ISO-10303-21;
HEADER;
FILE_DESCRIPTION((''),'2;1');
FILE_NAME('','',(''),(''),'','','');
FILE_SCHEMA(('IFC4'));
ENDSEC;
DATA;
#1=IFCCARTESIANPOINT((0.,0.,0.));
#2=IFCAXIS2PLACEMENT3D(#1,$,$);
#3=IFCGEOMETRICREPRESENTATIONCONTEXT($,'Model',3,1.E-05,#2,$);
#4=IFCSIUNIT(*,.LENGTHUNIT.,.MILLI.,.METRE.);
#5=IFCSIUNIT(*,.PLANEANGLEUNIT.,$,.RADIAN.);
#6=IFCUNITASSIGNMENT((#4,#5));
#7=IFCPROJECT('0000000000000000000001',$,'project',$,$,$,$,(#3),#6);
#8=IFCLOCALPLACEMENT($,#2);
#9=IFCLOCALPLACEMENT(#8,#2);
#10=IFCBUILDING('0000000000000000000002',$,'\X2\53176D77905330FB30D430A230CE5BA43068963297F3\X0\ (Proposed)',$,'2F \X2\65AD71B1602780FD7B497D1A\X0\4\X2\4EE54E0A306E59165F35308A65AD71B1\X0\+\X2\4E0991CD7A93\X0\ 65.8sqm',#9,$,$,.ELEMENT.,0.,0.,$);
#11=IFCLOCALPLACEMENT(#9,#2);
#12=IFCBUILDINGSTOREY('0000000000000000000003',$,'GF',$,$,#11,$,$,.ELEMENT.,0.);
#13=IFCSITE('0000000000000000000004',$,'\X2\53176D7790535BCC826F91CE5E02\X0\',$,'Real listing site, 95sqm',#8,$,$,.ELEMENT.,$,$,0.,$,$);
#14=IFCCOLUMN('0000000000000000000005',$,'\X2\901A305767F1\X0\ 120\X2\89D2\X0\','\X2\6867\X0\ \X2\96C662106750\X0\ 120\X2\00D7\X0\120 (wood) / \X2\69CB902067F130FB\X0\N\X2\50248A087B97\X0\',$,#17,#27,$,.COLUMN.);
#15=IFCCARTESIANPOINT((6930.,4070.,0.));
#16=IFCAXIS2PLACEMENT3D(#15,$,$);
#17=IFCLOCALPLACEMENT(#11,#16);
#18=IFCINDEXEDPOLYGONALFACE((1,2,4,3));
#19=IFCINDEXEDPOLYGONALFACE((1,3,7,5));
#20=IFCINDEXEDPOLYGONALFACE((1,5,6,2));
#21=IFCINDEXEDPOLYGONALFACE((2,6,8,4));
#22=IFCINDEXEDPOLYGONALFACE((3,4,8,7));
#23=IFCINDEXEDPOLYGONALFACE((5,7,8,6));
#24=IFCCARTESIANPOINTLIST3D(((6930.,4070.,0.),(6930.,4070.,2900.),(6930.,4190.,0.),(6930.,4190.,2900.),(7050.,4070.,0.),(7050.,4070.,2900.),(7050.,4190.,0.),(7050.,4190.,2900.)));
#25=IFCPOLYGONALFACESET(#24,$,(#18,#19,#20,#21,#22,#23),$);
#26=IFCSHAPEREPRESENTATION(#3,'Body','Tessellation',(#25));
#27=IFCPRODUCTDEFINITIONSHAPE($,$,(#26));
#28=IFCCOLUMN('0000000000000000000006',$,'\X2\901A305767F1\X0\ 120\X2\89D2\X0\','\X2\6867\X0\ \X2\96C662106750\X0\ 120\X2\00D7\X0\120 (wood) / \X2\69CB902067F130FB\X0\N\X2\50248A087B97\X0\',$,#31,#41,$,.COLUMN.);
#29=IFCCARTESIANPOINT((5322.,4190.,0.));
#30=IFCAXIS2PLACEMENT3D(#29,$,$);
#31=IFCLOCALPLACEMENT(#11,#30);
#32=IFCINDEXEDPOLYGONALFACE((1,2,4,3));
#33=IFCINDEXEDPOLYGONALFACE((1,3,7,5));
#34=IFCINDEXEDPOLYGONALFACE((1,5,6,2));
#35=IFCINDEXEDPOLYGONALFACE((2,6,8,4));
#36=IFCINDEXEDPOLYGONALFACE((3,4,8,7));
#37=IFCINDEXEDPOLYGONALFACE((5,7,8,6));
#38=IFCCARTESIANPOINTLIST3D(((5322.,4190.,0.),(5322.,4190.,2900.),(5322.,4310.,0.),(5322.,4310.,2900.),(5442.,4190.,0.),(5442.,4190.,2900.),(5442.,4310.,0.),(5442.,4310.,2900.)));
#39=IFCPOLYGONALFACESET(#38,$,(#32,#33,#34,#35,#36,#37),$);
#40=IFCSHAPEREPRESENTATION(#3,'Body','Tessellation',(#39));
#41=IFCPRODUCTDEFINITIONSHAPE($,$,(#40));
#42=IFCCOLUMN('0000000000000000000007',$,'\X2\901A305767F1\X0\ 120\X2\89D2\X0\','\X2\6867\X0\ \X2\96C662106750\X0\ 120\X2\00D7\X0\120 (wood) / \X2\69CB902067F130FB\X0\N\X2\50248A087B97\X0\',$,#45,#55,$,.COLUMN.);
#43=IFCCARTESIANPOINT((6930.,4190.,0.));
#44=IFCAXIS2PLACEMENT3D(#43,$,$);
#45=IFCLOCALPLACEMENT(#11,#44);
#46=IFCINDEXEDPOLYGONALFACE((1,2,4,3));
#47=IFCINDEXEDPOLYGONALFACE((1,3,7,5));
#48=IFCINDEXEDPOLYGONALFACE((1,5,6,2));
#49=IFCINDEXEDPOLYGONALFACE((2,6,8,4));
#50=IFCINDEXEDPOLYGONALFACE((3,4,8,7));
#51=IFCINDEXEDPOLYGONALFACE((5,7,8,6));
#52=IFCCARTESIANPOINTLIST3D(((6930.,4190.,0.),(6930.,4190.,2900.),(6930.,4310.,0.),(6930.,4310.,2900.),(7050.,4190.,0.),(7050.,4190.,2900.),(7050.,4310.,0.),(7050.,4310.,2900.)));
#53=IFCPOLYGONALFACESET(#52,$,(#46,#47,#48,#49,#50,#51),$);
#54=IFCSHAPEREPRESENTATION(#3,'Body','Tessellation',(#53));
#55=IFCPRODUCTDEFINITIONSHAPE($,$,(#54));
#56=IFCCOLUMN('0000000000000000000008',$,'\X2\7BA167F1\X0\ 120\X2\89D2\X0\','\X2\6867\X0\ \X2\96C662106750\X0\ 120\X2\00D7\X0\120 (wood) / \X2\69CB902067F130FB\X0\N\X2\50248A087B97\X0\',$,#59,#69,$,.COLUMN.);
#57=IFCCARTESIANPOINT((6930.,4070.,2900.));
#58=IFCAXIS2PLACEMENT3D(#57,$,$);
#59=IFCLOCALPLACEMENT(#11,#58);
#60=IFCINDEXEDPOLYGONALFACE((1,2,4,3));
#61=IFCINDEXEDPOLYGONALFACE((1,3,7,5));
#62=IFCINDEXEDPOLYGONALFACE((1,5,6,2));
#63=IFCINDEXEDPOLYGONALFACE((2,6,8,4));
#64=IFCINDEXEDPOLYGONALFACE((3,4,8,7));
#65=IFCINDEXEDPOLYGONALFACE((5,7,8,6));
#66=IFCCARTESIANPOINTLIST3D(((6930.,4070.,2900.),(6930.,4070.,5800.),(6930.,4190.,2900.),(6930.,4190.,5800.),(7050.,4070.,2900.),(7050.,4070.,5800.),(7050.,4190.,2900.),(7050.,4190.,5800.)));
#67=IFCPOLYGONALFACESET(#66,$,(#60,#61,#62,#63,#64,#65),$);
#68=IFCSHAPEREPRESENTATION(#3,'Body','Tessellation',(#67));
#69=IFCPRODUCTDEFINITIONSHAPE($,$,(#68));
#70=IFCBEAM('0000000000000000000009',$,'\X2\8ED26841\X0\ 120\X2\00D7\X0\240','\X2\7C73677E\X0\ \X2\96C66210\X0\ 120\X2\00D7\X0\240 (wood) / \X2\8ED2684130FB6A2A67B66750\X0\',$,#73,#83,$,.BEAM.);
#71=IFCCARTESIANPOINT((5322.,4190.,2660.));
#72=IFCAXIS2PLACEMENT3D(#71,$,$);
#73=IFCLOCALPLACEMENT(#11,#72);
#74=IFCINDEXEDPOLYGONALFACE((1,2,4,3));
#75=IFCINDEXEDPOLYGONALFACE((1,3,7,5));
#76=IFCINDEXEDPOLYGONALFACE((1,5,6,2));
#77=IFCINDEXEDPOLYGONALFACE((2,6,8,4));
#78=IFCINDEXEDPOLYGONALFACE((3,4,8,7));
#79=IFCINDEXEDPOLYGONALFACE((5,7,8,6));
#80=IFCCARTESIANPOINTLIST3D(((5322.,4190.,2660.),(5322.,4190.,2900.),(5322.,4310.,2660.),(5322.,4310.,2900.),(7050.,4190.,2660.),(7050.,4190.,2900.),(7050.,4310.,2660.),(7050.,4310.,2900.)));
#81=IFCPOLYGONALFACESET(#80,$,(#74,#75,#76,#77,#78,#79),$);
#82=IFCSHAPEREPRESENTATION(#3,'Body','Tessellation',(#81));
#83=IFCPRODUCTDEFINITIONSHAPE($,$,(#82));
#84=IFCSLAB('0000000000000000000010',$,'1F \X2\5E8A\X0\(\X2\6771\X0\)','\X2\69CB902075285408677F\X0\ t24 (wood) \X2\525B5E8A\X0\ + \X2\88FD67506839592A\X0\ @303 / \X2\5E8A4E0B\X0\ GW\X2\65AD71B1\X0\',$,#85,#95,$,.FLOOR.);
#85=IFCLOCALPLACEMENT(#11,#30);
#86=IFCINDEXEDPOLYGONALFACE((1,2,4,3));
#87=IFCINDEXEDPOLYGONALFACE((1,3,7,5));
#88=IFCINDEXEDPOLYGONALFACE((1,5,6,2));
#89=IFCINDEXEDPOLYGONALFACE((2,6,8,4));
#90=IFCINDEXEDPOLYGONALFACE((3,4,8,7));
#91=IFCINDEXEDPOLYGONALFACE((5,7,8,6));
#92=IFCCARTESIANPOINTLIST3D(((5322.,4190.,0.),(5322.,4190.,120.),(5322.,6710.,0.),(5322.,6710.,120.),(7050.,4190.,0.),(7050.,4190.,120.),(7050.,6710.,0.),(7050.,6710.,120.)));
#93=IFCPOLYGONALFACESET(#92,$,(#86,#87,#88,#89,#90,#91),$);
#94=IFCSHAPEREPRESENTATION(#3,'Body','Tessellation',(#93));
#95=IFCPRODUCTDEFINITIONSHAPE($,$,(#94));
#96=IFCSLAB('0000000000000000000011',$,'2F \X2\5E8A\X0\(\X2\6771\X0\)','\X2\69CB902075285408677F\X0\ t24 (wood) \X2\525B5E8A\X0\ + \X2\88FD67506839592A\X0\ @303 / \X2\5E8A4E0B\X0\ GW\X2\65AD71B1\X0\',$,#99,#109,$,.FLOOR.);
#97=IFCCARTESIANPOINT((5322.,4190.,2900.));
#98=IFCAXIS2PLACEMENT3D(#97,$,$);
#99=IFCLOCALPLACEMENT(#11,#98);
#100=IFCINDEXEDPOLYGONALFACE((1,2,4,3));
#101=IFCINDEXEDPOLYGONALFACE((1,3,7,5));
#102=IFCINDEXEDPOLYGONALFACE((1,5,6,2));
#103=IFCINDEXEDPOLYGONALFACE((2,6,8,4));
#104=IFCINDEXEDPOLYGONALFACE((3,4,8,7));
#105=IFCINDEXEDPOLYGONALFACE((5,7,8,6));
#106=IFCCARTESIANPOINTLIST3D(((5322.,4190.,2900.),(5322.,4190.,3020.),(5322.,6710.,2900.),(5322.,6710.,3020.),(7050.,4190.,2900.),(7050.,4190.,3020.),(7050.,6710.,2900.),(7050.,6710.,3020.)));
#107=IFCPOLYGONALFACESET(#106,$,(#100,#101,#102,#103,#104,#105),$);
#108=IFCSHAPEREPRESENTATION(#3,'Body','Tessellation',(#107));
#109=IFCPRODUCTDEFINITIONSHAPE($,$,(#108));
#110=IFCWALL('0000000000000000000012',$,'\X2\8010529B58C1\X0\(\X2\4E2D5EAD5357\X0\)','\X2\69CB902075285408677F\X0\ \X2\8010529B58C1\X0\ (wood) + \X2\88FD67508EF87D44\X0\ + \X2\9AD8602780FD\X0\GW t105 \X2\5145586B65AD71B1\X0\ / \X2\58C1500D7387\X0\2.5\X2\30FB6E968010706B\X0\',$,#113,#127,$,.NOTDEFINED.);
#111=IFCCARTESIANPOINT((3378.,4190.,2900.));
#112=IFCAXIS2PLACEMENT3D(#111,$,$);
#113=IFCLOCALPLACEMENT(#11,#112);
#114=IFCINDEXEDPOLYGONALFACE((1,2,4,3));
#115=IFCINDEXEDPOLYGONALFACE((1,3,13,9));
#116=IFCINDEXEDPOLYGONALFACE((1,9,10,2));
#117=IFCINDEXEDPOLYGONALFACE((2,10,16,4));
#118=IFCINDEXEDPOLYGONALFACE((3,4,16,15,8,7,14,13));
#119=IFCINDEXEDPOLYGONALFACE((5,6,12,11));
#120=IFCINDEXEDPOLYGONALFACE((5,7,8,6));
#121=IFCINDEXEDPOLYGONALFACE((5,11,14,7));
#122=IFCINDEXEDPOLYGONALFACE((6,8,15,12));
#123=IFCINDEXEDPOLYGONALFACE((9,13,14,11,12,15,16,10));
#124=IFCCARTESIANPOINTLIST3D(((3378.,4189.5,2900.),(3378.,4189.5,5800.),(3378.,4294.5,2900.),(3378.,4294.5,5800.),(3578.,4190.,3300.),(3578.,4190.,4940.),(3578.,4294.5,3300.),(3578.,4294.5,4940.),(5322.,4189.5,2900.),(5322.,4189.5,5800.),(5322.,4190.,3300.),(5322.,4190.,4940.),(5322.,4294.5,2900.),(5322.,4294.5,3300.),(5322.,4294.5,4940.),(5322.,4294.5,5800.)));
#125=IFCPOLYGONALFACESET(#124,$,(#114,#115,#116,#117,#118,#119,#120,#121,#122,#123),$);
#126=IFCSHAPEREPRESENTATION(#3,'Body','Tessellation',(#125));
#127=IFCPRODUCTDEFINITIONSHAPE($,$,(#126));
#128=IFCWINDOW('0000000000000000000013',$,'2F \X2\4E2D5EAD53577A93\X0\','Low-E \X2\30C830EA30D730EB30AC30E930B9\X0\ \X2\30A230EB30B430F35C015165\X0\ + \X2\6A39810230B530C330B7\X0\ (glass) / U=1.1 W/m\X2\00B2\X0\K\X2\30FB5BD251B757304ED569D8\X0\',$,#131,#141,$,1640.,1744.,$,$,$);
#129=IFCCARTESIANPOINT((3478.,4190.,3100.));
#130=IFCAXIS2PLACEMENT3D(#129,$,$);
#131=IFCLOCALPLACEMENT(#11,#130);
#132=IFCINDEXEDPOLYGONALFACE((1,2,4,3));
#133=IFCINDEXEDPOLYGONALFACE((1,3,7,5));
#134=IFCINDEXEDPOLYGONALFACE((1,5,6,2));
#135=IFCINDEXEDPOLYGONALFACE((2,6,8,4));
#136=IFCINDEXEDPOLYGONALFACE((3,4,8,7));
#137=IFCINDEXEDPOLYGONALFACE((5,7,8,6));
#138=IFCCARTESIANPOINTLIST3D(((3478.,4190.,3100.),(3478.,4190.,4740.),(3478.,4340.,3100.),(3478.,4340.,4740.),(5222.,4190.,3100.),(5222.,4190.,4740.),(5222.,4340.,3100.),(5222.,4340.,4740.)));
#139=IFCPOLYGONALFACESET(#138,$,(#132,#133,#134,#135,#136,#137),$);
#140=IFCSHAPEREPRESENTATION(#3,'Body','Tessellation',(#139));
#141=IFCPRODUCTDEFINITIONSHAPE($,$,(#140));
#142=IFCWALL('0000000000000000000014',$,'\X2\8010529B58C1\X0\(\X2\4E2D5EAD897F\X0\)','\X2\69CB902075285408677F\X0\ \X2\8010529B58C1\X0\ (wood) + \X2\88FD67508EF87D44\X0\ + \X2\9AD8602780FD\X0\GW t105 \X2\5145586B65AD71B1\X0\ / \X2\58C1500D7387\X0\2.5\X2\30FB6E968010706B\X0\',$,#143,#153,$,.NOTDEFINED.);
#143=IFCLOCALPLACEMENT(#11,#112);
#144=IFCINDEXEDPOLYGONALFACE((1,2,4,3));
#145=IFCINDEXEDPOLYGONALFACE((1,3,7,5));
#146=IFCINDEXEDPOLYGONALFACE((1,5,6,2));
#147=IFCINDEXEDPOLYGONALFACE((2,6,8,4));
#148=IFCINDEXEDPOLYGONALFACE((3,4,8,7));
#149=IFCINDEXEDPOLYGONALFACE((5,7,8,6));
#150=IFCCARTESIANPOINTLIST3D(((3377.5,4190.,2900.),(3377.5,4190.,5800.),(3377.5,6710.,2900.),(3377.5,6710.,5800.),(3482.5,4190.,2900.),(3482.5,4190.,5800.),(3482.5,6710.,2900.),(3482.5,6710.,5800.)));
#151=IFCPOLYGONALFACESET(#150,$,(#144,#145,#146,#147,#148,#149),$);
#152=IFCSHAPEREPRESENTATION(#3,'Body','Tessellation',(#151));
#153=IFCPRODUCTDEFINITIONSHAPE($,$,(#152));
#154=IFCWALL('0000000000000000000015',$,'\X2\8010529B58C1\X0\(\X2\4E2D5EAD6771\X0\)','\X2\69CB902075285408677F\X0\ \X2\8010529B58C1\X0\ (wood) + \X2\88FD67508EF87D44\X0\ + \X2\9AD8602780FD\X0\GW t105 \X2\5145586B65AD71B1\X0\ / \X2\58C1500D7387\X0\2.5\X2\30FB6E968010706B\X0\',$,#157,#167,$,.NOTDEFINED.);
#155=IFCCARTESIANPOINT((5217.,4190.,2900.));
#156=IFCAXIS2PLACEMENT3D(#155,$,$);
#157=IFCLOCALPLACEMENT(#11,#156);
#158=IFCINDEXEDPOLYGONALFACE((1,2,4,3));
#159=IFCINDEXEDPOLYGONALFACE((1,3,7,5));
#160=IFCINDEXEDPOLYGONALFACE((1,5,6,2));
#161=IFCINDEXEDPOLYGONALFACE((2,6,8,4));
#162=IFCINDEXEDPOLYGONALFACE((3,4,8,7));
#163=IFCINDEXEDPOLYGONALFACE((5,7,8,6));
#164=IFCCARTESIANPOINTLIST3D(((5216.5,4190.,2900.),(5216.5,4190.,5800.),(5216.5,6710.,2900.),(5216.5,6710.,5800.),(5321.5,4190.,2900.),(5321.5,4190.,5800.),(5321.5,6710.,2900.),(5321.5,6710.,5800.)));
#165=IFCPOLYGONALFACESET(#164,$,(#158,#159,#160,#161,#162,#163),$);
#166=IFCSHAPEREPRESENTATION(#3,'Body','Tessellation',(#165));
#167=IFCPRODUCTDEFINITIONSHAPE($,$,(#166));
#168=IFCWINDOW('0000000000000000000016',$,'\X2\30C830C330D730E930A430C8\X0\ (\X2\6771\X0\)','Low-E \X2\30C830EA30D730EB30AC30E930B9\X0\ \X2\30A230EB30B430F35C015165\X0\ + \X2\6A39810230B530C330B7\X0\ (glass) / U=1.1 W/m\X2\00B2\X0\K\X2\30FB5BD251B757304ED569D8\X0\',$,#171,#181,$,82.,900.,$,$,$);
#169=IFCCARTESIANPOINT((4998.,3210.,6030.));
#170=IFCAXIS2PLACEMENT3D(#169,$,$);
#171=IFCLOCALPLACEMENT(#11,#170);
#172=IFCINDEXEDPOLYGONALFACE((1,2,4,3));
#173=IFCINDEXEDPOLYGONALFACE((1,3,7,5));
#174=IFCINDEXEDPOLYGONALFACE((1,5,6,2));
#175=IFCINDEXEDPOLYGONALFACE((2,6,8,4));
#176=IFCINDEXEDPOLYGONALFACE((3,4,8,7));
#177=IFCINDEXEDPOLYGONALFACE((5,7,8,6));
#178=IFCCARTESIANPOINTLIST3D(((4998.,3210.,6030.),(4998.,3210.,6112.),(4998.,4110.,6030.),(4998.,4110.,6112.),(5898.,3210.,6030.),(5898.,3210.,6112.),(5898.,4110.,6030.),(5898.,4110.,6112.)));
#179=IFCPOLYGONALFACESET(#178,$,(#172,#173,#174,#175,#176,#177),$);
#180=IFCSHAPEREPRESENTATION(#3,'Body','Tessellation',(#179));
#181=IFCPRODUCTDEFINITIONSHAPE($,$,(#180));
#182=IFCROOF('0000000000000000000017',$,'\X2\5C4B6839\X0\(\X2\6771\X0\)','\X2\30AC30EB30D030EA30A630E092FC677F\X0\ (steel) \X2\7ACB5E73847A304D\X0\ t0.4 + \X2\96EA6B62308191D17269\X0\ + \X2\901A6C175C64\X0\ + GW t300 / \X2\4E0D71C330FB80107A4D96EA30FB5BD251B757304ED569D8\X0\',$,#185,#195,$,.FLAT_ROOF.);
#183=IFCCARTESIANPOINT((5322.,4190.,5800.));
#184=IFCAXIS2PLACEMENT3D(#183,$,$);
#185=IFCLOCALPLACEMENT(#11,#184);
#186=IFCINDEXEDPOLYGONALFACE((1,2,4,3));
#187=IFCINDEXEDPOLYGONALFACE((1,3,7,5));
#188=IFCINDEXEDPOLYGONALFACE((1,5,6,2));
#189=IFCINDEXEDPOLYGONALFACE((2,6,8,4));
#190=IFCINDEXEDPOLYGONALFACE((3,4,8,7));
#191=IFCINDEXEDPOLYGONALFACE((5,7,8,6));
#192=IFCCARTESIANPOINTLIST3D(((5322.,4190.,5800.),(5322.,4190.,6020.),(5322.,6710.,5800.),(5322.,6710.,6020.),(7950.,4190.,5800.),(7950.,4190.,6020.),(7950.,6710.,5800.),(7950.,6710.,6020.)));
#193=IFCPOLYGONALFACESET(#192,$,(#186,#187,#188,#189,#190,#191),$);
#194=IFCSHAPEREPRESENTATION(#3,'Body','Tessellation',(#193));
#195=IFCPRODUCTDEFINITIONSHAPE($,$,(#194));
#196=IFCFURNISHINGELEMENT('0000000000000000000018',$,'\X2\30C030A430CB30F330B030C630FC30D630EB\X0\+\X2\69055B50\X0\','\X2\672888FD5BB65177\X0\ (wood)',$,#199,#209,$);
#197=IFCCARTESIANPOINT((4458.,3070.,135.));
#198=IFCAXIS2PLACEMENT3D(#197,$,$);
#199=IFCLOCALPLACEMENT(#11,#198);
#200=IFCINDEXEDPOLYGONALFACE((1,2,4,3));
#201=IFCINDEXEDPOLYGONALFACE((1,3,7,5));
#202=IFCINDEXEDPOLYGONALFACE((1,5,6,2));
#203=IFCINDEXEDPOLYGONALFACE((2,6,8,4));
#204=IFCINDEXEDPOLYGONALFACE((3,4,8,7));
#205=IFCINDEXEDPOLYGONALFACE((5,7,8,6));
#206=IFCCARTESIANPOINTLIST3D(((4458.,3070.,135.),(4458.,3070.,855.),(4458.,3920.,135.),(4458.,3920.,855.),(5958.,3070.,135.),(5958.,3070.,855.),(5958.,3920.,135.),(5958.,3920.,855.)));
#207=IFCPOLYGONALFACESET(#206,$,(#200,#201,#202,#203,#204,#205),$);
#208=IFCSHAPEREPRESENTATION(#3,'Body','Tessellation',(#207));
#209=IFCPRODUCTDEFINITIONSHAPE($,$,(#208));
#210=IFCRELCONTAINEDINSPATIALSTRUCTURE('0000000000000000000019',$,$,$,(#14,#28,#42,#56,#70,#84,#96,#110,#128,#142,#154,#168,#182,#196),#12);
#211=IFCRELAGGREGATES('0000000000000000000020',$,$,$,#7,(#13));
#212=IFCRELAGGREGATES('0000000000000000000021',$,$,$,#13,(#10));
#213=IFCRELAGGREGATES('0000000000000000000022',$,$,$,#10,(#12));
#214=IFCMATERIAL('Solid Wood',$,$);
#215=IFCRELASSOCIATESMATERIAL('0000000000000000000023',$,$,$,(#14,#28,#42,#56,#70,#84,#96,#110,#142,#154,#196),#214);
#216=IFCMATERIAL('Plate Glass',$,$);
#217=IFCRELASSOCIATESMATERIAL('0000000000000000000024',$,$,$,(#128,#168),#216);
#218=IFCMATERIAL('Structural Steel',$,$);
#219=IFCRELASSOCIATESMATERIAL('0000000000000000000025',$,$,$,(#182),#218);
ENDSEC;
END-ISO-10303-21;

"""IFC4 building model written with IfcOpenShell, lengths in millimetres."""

from ifc_helpers import new_model, si_unit, frame, frame_2d, origin, place, context, project, spatial, rectangle, extrude, material, element, fill, save


model = new_model("IFC4")

# Units and contexts
model_context = context("Model", 3, precision=1e-05, world=origin())
ifc_project = project(units=[si_unit("LENGTHUNIT", "METRE", prefix="MILLI"), si_unit("PLANEANGLEUNIT", "RADIAN")], contexts=[model_context])

# Site, building, storey
site_placement = place(None, origin())
site = spatial("IfcSite", under=ifc_project, at=site_placement, Name="北海道富良野市", ObjectType="Real listing site, 95sqm", CompositionType="ELEMENT", RefElevation=0.0)
building_placement = place(site_placement, origin())
building = spatial("IfcBuilding", under=site, at=building_placement, Name="北海道・ピアノ室と防音 (Proposed)", ObjectType="2F 断熱性能等級4以上の外張り断熱+三重窓 65.8sqm", CompositionType="ELEMENT", ElevationOfRefHeight=0.0, ElevationOfTerrain=0.0)
storey_placement = place(building_placement, origin())
storey = spatial("IfcBuildingStorey", under=building, at=storey_placement, Name="GF", CompositionType="ELEMENT", Elevation=0.0)

# Columns
ifc_material_1 = material(Name="Solid Wood")
column_1_placement = place(storey_placement, frame((6930.0, 4070.0, 0.0)))
element("IfcColumn", 1, at=column_1_placement, inside=storey, material=ifc_material_1, Name="通し柱 120角", Description="桧 集成材 120×120 (wood) / 構造柱・N値計算", PredefinedType="COLUMN", context=model_context, shape_type="SweptSolid", body=[
    extrude(rectangle(XDim=120.0, YDim=120.0, at=frame_2d((60.0, 60.0))), frame((6930.0, 4070.0, 0.0)), (0.0, 0.0, 1.0), 2900.0),
])
column_2_placement = place(storey_placement, frame((5322.0, 4190.0, 0.0)))
element("IfcColumn", 2, at=column_2_placement, inside=storey, material=ifc_material_1, Name="通し柱 120角", Description="桧 集成材 120×120 (wood) / 構造柱・N値計算", PredefinedType="COLUMN", context=model_context, shape_type="SweptSolid", body=[
    extrude(rectangle(XDim=120.0, YDim=120.0, at=frame_2d((60.0, 60.0))), frame((5322.0, 4190.0, 0.0)), (0.0, 0.0, 1.0), 2900.0),
])
column_3_placement = place(storey_placement, frame((6930.0, 4190.0, 0.0)))
element("IfcColumn", 3, at=column_3_placement, inside=storey, material=ifc_material_1, Name="通し柱 120角", Description="桧 集成材 120×120 (wood) / 構造柱・N値計算", PredefinedType="COLUMN", context=model_context, shape_type="SweptSolid", body=[
    extrude(rectangle(XDim=120.0, YDim=120.0, at=frame_2d((60.0, 60.0))), frame((6930.0, 4190.0, 0.0)), (0.0, 0.0, 1.0), 2900.0),
])
column_4_placement = place(storey_placement, frame((6930.0, 4070.0, 2900.0)))
element("IfcColumn", 4, at=column_4_placement, inside=storey, material=ifc_material_1, Name="管柱 120角", Description="桧 集成材 120×120 (wood) / 構造柱・N値計算", PredefinedType="COLUMN", context=model_context, shape_type="SweptSolid", body=[
    extrude(rectangle(XDim=120.0, YDim=120.0, at=frame_2d((60.0, 60.0))), frame((6930.0, 4070.0, 2900.0)), (0.0, 0.0, 1.0), 2900.0),
])

# Beam
beam_1_placement = place(storey_placement, frame((5322.0, 4190.0, 2660.0)))
element("IfcBeam", 5, at=beam_1_placement, inside=storey, material=ifc_material_1, Name="軒桁 120×240", Description="米松 集成 120×240 (wood) / 軒桁・横架材", PredefinedType="BEAM", context=model_context, shape_type="SweptSolid", body=[
    extrude(rectangle(XDim=1728.0, YDim=120.0, at=frame_2d((864.0, 60.0))), frame((5322.0, 4190.0, 2660.0)), (0.0, 0.0, 1.0), 240.0),
])

# Slabs
slab_1_placement = place(storey_placement, frame((5322.0, 4190.0, 0.0)))
element("IfcSlab", 6, at=slab_1_placement, inside=storey, material=ifc_material_1, Name="1F 床(東)", Description="構造用合板 t24 (wood) 剛床 + 製材根太 @303 / 床下 GW断熱", PredefinedType="FLOOR", context=model_context, shape_type="SweptSolid", body=[
    extrude(rectangle(XDim=1728.0, YDim=2520.0, at=frame_2d((864.0, 1260.0))), frame((5322.0, 4190.0, 0.0)), (0.0, 0.0, 1.0), 120.0),
])
slab_2_placement = place(storey_placement, frame((5322.0, 4190.0, 2900.0)))
element("IfcSlab", 7, at=slab_2_placement, inside=storey, material=ifc_material_1, Name="2F 床(東)", Description="構造用合板 t24 (wood) 剛床 + 製材根太 @303 / 床下 GW断熱", PredefinedType="FLOOR", context=model_context, shape_type="SweptSolid", body=[
    extrude(rectangle(XDim=1728.0, YDim=2520.0, at=frame_2d((864.0, 1260.0))), frame((5322.0, 4190.0, 2900.0)), (0.0, 0.0, 1.0), 120.0),
])

# Wall, opening, window
wall_1_placement = place(storey_placement, frame((3378.0, 4190.0, 2900.0)))
wall_1 = element("IfcWall", 8, at=wall_1_placement, inside=storey, material=ifc_material_1, Name="耐力壁(中庭南)", Description="構造用合板 耐力壁 (wood) + 製材軸組 + 高性能GW t105 充填断熱 / 壁倍率2.5・準耐火", PredefinedType="NOTDEFINED", context=model_context, shape_type="SweptSolid", body=[
    extrude(rectangle(XDim=1944.0, YDim=105.0, at=frame_2d((972.0, 52.0))), frame((3378.0, 4190.0, 2900.0)), (0.0, 0.0, 1.0), 2900.0),
])
opening_placement = place(storey_placement, frame((3478.0, 4190.0, 3100.0)))
opening = element("IfcOpeningElement", 9, at=opening_placement, cuts=wall_1, PredefinedType="NOTDEFINED", context=model_context, shape_type="SweptSolid", body=[
    extrude(rectangle(XDim=1744.0, YDim=150.0, at=frame_2d((872.0, 75.0))), frame((3478.0, 4190.0, 3100.0)), (0.0, 0.0, 1.0), 1640.0),
])
ifc_material_2 = material(Name="Plate Glass")
window_1_placement = place(storey_placement, frame((3478.0, 4190.0, 3100.0)))
window_1 = element("IfcWindow", 10, at=window_1_placement, inside=storey, material=ifc_material_2, Name="2F 中庭南窓", Description="Low-E トリプルガラス アルゴン封入 + 樹脂サッシ (glass) / U=1.1 W/m²K・寒冷地仕様", OverallHeight=1640.0, OverallWidth=1744.0, context=model_context, shape_type="SweptSolid", body=[
    extrude(rectangle(XDim=1744.0, YDim=150.0, at=frame_2d((872.0, 75.0))), frame((3478.0, 4190.0, 3100.0)), (0.0, 0.0, 1.0), 1640.0),
])
fill(opening, window_1)

# Walls
wall_2_placement = place(storey_placement, frame((3378.0, 4190.0, 2900.0)))
element("IfcWall", 11, at=wall_2_placement, inside=storey, material=ifc_material_1, Name="耐力壁(中庭西)", Description="構造用合板 耐力壁 (wood) + 製材軸組 + 高性能GW t105 充填断熱 / 壁倍率2.5・準耐火", PredefinedType="NOTDEFINED", context=model_context, shape_type="SweptSolid", body=[
    extrude(rectangle(XDim=105.0, YDim=2520.0, at=frame_2d((52.0, 1260.0))), frame((3378.0, 4190.0, 2900.0)), (0.0, 0.0, 1.0), 2900.0),
])
wall_3_placement = place(storey_placement, frame((5217.0, 4190.0, 2900.0)))
element("IfcWall", 12, at=wall_3_placement, inside=storey, material=ifc_material_1, Name="耐力壁(中庭東)", Description="構造用合板 耐力壁 (wood) + 製材軸組 + 高性能GW t105 充填断熱 / 壁倍率2.5・準耐火", PredefinedType="NOTDEFINED", context=model_context, shape_type="SweptSolid", body=[
    extrude(rectangle(XDim=105.0, YDim=2520.0, at=frame_2d((52.0, 1260.0))), frame((5217.0, 4190.0, 2900.0)), (0.0, 0.0, 1.0), 2900.0),
])

# Window
window_2_placement = place(storey_placement, frame((4998.0, 3210.0, 6030.0)))
element("IfcWindow", 13, at=window_2_placement, inside=storey, material=ifc_material_2, Name="トップライト (東)", Description="Low-E トリプルガラス アルゴン封入 + 樹脂サッシ (glass) / U=1.1 W/m²K・寒冷地仕様", OverallHeight=82.0, OverallWidth=900.0, context=model_context, shape_type="SweptSolid", body=[
    extrude(rectangle(XDim=900.0, YDim=900.0, at=frame_2d((450.0, 450.0))), frame((4998.0, 3210.0, 6030.0)), (0.0, 0.0, 1.0), 82.0),
])

# Roof
ifc_material_3 = material(Name="Structural Steel")
for number, where, name in (
    (14, (5322.0, 4190.0, 5800.0), "屋根(東)"),
):
    element("IfcRoof", number, at=place(storey_placement, frame(where)), inside=storey, material=ifc_material_3, Name=name, Description="ガルバリウム鋼板 (steel) 立平葺き t0.4 + 雪止め金物 + 通気層 + GW t300 / 不燃・耐積雪・寒冷地仕様", PredefinedType="FLAT_ROOF", context=model_context, shape_type="SweptSolid", body=[
        extrude(rectangle(XDim=2628.0, YDim=2520.0, at=frame_2d((1314.0, 1260.0))), frame((5322.0, 4190.0, 5800.0)), (0.0, 0.0, 1.0), 220.0),
    ])

# Furnishing element
furnishing_1_placement = place(storey_placement, frame((4458.0, 3070.0, 135.0)))
element("IfcFurnishingElement", 15, at=furnishing_1_placement, inside=storey, material=ifc_material_1, Name="ダイニングテーブル+椅子", Description="木製家具 (wood)", context=model_context, shape_type="SweptSolid", body=[
    extrude(rectangle(XDim=1500.0, YDim=850.0, at=frame_2d((750.0, 425.0))), frame((4458.0, 3070.0, 135.0)), (0.0, 0.0, 1.0), 720.0),
])

save(model, "model.ifc")
